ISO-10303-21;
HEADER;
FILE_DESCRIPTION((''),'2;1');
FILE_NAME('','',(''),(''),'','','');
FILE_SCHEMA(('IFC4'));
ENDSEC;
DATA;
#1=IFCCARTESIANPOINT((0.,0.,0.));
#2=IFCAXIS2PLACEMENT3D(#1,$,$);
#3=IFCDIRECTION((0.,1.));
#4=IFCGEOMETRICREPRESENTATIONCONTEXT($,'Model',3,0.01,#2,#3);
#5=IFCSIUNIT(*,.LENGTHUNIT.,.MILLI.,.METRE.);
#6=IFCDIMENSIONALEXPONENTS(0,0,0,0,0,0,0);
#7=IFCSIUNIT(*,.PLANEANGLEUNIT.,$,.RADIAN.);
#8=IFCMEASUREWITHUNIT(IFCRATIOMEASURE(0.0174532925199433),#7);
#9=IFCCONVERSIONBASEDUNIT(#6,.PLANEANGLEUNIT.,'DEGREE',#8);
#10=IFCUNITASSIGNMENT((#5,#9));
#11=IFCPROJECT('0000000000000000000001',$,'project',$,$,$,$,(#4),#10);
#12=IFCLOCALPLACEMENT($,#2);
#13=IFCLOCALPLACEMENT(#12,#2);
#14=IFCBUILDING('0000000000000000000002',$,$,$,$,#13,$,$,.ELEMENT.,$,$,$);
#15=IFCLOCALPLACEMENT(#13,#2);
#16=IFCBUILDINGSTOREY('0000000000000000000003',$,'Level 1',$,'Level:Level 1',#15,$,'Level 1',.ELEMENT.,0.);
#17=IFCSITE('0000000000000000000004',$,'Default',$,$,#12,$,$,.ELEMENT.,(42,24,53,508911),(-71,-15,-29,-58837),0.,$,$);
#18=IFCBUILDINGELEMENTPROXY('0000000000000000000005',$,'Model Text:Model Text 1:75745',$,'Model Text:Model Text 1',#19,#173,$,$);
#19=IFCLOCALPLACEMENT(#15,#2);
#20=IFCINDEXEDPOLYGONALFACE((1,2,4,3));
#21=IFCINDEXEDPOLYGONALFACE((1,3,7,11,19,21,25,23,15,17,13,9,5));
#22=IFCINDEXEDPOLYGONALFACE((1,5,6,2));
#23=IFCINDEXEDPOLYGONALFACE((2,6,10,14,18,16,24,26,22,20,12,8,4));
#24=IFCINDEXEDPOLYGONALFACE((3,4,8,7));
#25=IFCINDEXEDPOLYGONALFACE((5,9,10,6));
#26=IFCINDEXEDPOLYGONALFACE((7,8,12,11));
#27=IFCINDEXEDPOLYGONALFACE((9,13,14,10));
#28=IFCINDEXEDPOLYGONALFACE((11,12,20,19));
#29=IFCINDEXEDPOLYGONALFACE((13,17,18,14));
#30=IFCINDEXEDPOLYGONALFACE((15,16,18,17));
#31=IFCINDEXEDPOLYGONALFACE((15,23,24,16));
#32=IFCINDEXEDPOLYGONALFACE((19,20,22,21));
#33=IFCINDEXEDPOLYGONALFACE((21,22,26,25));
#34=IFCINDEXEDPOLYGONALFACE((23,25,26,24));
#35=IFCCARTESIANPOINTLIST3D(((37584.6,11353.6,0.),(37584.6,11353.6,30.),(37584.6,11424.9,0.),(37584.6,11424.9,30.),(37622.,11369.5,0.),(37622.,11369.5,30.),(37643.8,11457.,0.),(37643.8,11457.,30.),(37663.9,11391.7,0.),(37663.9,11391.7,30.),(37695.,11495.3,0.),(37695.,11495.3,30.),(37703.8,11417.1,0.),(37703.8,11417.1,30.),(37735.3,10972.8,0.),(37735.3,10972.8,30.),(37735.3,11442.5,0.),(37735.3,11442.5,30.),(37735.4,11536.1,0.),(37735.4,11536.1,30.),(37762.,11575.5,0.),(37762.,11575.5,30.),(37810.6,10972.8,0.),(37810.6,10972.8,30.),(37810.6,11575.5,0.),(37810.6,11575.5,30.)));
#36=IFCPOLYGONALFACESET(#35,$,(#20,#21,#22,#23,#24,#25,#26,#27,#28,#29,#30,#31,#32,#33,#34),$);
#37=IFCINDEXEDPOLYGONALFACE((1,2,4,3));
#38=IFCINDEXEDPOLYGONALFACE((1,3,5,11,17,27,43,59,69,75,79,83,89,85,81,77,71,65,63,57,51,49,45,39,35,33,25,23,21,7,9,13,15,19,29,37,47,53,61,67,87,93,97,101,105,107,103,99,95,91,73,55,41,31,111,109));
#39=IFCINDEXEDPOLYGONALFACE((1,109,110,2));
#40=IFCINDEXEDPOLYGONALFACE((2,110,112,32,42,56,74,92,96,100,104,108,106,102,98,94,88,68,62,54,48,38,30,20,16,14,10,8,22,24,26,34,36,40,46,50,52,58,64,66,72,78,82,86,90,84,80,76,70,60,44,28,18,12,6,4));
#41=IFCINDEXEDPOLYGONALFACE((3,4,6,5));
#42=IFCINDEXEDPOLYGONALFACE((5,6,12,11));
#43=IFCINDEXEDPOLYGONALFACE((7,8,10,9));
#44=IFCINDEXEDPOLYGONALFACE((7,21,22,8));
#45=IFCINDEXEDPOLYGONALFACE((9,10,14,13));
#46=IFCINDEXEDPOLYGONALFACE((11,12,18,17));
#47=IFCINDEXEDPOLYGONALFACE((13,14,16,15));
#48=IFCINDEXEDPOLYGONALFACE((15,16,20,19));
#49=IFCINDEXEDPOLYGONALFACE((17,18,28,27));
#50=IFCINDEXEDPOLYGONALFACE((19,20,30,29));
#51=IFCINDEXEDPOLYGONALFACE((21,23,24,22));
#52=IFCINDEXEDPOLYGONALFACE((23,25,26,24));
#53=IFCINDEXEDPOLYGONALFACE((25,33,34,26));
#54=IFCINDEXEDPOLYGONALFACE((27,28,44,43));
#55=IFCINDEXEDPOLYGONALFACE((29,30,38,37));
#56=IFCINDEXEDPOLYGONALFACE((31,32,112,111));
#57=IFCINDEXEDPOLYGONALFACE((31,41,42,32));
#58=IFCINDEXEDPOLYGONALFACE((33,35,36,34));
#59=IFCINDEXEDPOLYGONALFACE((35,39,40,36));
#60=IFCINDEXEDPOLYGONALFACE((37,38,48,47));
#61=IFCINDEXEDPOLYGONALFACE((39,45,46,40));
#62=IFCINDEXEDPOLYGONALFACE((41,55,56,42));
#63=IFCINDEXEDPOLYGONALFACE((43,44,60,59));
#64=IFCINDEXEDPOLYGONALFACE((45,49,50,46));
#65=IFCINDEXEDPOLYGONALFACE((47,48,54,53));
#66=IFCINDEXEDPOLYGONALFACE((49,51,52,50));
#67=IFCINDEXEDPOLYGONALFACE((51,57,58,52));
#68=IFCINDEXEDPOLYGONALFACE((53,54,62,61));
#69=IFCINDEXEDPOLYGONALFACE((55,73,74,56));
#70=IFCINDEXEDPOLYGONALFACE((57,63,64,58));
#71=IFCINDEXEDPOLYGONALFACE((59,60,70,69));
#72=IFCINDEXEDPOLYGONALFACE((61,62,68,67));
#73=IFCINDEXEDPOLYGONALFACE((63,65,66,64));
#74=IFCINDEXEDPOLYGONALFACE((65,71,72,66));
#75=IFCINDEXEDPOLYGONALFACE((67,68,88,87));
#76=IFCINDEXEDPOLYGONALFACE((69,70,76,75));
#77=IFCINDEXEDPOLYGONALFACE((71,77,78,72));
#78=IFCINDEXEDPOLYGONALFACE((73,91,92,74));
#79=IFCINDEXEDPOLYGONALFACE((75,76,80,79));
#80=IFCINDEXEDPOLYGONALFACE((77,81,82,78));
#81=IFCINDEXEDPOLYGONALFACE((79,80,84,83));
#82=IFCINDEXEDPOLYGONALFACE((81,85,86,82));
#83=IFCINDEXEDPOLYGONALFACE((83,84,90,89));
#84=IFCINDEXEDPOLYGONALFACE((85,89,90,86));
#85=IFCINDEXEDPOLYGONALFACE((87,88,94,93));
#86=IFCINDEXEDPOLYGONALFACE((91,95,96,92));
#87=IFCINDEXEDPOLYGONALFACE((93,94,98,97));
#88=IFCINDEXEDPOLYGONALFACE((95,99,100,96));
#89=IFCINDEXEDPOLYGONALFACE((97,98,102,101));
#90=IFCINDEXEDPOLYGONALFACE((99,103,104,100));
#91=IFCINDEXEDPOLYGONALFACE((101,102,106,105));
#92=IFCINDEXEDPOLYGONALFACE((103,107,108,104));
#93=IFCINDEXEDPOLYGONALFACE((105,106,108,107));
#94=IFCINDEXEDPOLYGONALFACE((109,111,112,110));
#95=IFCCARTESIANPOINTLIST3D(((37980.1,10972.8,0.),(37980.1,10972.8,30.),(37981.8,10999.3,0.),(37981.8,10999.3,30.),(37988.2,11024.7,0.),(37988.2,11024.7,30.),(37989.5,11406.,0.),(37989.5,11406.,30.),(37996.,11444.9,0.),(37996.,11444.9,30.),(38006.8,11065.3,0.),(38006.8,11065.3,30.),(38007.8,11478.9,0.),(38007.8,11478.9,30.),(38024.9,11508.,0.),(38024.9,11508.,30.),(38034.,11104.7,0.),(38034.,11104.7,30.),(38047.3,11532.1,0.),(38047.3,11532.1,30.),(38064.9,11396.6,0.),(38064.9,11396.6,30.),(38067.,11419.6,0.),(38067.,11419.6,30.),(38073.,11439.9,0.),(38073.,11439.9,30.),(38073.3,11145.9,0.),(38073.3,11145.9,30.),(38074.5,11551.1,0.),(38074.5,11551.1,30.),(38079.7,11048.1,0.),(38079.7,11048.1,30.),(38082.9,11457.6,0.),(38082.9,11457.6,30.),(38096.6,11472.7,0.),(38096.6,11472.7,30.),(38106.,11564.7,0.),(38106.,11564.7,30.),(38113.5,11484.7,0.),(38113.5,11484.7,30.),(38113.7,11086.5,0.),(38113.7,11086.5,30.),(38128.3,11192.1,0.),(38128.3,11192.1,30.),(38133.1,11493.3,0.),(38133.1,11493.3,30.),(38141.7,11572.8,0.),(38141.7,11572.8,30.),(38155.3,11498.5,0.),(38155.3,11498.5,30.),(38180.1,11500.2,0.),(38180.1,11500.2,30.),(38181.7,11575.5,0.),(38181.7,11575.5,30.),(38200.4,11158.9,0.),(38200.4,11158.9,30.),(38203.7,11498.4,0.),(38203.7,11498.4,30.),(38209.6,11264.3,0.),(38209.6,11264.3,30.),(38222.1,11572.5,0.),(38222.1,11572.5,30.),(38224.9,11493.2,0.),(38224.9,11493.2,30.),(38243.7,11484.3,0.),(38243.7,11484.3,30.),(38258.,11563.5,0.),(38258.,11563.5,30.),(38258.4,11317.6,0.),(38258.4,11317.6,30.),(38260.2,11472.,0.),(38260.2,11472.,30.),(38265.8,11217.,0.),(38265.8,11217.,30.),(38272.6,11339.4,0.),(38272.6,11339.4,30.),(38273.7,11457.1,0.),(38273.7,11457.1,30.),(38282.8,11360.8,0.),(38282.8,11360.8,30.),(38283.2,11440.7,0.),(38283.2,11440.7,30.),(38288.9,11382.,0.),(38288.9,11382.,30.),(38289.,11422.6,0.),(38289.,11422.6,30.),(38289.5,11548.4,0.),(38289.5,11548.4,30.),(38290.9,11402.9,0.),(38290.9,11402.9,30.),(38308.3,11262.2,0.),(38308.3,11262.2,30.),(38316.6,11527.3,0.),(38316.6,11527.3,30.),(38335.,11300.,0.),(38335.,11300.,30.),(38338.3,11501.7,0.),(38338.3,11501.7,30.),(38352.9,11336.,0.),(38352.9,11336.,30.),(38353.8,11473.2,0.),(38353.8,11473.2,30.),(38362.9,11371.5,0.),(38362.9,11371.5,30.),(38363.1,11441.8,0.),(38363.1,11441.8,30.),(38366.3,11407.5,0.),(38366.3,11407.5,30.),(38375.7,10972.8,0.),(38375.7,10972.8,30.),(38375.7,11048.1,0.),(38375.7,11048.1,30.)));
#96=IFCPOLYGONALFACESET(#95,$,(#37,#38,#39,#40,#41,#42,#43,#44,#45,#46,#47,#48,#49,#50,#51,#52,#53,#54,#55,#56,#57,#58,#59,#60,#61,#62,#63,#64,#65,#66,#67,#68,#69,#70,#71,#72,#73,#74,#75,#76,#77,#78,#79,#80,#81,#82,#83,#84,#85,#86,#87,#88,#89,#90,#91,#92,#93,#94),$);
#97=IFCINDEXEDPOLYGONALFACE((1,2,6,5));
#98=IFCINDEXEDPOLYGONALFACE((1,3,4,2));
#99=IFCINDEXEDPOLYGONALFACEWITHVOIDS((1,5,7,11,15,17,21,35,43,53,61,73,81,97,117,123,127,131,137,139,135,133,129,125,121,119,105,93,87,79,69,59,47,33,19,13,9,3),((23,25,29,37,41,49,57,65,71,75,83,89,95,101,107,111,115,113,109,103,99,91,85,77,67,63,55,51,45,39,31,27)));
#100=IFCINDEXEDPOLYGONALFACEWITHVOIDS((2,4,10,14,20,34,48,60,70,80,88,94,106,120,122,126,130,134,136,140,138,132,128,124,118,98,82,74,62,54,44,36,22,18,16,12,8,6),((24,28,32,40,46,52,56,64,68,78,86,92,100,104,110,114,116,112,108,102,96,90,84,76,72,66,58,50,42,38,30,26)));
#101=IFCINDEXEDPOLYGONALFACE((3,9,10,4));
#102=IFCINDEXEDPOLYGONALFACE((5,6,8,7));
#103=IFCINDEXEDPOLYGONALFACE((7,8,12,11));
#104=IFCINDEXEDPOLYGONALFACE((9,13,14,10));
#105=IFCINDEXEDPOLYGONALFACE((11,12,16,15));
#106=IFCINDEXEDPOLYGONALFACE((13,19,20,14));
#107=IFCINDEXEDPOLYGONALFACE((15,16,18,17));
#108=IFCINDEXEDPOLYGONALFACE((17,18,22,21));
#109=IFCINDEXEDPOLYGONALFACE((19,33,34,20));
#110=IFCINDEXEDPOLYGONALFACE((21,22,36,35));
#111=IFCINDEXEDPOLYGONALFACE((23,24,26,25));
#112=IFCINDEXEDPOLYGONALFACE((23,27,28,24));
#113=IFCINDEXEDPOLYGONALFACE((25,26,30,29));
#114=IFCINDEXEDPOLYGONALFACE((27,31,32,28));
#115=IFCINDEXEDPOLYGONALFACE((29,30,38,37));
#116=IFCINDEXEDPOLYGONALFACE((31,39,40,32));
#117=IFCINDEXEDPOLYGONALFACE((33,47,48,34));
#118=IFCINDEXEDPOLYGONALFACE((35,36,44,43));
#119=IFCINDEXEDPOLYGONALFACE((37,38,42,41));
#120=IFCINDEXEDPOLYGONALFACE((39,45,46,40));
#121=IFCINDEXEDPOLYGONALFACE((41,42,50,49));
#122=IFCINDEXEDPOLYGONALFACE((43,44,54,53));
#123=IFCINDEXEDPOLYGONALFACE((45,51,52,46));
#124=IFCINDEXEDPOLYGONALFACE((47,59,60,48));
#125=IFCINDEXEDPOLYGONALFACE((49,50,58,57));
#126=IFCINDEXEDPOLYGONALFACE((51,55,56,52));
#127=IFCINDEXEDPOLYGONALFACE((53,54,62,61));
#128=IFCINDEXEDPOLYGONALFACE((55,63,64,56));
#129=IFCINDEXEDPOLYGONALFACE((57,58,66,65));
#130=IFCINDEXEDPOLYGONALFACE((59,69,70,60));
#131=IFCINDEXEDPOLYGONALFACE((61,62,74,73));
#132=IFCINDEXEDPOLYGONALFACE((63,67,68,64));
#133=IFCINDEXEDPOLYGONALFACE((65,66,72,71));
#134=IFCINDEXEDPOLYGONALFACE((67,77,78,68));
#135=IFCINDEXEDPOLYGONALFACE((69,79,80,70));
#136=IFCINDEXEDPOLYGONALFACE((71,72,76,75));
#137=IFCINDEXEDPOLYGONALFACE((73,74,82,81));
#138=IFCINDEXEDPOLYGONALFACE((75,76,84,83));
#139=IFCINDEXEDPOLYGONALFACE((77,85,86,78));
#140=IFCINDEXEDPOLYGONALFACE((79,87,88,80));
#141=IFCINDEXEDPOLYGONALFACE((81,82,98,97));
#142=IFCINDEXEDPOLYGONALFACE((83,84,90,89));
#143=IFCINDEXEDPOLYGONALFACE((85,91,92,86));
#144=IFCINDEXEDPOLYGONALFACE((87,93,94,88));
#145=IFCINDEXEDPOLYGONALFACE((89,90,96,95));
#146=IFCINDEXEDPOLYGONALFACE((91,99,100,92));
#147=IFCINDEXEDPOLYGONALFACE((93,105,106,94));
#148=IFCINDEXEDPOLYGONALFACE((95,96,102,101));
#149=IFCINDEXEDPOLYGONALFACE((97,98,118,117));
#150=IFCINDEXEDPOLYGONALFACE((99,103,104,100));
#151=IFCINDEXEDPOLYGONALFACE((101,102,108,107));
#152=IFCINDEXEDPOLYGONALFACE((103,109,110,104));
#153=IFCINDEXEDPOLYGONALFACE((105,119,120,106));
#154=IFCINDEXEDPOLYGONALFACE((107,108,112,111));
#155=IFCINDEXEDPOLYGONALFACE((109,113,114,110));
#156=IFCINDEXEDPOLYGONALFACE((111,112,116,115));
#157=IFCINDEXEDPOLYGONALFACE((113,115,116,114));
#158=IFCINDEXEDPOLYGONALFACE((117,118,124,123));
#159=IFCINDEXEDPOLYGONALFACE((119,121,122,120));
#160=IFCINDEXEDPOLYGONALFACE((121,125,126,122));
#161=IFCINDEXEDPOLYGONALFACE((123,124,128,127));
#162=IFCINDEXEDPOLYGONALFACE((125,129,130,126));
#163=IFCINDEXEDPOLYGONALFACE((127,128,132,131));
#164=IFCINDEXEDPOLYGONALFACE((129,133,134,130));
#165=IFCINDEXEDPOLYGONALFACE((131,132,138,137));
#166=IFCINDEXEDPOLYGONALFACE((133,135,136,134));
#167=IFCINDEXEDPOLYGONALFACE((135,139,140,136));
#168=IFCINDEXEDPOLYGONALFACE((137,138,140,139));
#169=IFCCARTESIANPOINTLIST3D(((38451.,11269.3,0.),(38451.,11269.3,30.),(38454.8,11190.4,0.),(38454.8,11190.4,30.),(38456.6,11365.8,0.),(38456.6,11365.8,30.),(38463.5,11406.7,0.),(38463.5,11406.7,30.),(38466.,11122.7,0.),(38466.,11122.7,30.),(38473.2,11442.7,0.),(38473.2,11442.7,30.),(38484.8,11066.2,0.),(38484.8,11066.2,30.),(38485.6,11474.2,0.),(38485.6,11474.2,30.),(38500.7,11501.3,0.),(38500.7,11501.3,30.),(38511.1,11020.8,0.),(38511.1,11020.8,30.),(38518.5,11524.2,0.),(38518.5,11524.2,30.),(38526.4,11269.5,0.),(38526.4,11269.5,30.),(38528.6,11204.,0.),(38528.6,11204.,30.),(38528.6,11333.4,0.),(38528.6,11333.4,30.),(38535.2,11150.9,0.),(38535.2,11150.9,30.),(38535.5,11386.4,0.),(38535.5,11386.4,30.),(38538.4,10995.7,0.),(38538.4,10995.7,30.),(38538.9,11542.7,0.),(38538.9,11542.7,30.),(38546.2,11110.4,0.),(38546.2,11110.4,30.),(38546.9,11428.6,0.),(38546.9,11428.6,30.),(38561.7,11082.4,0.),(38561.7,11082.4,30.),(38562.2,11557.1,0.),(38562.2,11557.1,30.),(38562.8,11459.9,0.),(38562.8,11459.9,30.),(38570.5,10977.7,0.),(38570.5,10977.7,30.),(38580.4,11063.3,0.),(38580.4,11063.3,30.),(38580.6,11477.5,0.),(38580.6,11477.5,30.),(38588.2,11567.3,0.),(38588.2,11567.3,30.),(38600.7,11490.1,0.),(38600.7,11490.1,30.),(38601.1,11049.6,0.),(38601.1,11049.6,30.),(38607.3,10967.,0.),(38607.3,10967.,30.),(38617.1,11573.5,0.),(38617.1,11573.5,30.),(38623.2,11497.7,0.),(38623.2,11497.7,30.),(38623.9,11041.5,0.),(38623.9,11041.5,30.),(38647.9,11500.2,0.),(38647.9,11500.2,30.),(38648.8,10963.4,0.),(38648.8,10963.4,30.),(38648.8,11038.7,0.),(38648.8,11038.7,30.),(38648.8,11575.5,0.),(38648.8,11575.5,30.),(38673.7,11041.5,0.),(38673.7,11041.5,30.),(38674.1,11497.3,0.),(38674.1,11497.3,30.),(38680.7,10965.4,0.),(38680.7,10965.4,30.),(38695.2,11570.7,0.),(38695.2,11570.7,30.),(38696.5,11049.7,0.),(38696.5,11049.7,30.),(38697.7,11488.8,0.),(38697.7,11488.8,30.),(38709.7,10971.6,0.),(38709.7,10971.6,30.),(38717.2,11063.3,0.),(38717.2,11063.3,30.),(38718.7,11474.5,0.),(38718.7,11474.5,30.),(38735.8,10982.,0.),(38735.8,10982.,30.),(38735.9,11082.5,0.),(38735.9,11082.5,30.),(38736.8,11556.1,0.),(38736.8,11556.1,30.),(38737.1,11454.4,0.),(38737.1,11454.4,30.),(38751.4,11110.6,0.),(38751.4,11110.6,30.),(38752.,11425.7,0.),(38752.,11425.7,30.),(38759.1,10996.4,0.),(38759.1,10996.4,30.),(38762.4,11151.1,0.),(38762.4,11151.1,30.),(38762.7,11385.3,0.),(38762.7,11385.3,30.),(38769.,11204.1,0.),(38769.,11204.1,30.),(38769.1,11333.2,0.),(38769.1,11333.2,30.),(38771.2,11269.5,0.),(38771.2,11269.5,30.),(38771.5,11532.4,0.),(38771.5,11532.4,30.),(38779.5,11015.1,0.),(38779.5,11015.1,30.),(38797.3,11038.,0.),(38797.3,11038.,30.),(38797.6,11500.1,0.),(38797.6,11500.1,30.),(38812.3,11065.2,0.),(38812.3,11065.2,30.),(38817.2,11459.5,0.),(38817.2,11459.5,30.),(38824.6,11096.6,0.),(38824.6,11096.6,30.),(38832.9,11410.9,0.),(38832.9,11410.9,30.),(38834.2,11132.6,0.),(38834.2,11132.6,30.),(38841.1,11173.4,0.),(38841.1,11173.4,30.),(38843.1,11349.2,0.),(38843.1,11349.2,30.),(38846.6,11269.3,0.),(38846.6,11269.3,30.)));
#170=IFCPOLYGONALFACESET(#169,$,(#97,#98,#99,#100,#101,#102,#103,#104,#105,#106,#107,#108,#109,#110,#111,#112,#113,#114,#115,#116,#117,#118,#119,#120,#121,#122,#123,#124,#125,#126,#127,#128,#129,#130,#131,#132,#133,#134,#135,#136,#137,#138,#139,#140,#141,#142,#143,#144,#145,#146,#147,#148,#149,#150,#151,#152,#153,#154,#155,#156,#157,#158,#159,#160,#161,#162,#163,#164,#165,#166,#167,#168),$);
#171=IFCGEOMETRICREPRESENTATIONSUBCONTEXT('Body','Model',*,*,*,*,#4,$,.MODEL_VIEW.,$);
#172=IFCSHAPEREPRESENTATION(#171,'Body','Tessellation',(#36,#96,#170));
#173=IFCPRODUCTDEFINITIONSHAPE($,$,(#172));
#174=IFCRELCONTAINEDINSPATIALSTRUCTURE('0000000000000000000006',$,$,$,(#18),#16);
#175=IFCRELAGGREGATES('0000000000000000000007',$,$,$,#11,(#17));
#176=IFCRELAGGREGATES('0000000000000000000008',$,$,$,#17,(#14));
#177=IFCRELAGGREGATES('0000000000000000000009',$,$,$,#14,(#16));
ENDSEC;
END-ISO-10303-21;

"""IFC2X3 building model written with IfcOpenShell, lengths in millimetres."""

from ifc_helpers import new_model, entity, si_unit, converted_unit, direction, frame, origin, place, context, subcontext, project, spatial, polyline, outline, extrude, element, save


model = new_model("IFC2X3")

# Units and contexts
model_context = context("Model", 3, precision=0.01, world=origin(), true_north=direction((0.0, 1.0)))
body_context = subcontext(model_context, "Body", "Model", "MODEL_VIEW")
ifc_project = project(units=[si_unit("LENGTHUNIT", "METRE", prefix="MILLI"), converted_unit("PLANEANGLEUNIT", "DEGREE", entity("IfcRatioMeasure", 0.0174532925199433), si_unit("PLANEANGLEUNIT", "RADIAN"), dimensions=[0, 0, 0, 0, 0, 0, 0])], contexts=[model_context])

# Site, building, storey
site_placement = place(None, origin())
site = spatial("IfcSite", under=ifc_project, at=site_placement, Name="Default", CompositionType="ELEMENT", RefLatitude=(42, 24, 53, 508911), RefLongitude=(-71, -15, -29, -58837), RefElevation=0.0)
building_placement = place(site_placement, origin())
building = spatial("IfcBuilding", under=site, at=building_placement, CompositionType="ELEMENT")
storey_placement = place(building_placement, origin())
storey = spatial("IfcBuildingStorey", under=building, at=storey_placement, Name="Level 1", ObjectType="Level:Level 1", LongName="Level 1", CompositionType="ELEMENT", Elevation=0.0)

# Building element proxy
proxy_1_placement = place(storey_placement, origin())
element("IfcBuildingElementProxy", 1, at=proxy_1_placement, inside=storey, Name="Model Text:Model Text 1:75745", ObjectType="Model Text:Model Text 1", context=body_context, shape_type="SweptSolid", body=[
    extrude(outline(polyline([(-410.6, -111.6), (192.1, -111.6), (192.1, -63.1), (152.7, -36.4), (111.9, 4.0), (73.6, 55.2), (41.4, 114.4), (-29.8, 114.4), (-13.9, 77.0), (8.3, 35.1), (33.7, -4.8), (59.1, -36.3), (-410.6, -36.3), (-410.6, -111.6)])), frame((37699.0, 11383.4, 0.0), z_axis=(0.0, 0.0, 1.0), x_axis=(0.0, 1.0, 0.0)), (0.0, 0.0, 1.0), 30.0),
    extrude(outline(polyline([(-190.2, -317.5), (-190.2, -392.8), (205.4, -392.8), (203.7, -366.3), (197.3, -340.9), (178.7, -300.3), (151.5, -260.9), (112.2, -219.7), (57.2, -173.6), (-24.1, -101.3), (-72.9, -48.0), (-87.1, -26.3), (-97.3, -4.8), (-103.4, 16.4), (-105.4, 37.3), (-103.5, 57.0), (-97.7, 75.0), (-88.2, 91.5), (-74.7, 106.4), (-58.2, 118.7), (-39.4, 127.5), (-18.2, 132.8), (5.4, 134.6), (30.2, 132.9), (52.4, 127.7), (72.0, 119.1), (88.9, 107.1), (102.6, 92.0), (112.5, 74.3), (118.5, 54.0), (120.6, 31.0), (196.0, 40.4), (189.5, 79.3), (177.7, 113.3), (160.6, 142.4), (138.2, 166.5), (111.0, 185.5), (79.5, 199.1), (43.8, 207.2), (3.8, 209.9), (-36.6, 206.9), (-72.5, 197.9), (-104.0, 182.8), (-131.1, 161.7), (-152.8, 136.1), (-168.3, 107.6), (-177.6, 76.2), (-180.8, 41.9), (-177.4, 5.8), (-167.4, -29.6), (-149.5, -65.6), (-122.8, -103.4), (-80.3, -148.6), (-14.9, -206.7), (71.8, -279.1), (105.8, -317.5), (-190.2, -317.5)])), frame((38185.5, 11365.6, 0.0), z_axis=(0.0, 0.0, -1.0), x_axis=(-1.0, 0.0, 0.0)), (0.0, 0.0, -1.0), 30.0),
    extrude(outline(polyline([(-10.6, -198.7), (68.3, -198.7), (136.5, -190.7), (193.9, -174.7), (240.5, -150.6), (266.9, -124.4), (286.3, -93.2), (298.8, -57.0), (304.3, -15.7), (303.8, 16.2), (299.0, 45.5), (289.9, 72.1), (276.6, 96.0), (258.9, 117.3), (236.9, 136.2), (210.4, 152.5), (179.6, 166.3), (144.1, 177.6), (103.7, 186.3), (8.2, 196.4), (-71.8, 196.7), (-134.0, 189.4), (-183.3, 176.1), (-224.7, 158.4), (-258.2, 133.9), (-283.5, 100.3), (-300.1, 59.5), (-307.1, 13.4), (-306.6, -18.4), (-301.8, -47.5), (-292.8, -74.0), (-279.6, -97.9), (-262.0, -119.2), (-240.0, -138.1), (-213.6, -154.5), (-182.8, -168.4), (-147.3, -179.8), (-106.7, -188.6), (-10.6, -198.7)]), holes=[polyline([(-7.2, -123.5), (-71.0, -118.2), (-123.6, -108.8), (-165.2, -95.4), (-195.7, -78.0), (-212.4, -59.4), (-224.1, -38.7), (-230.6, -15.9), (-231.9, 8.9), (-227.8, 35.0), (-218.1, 58.1), (-202.8, 78.4), (-182.0, 95.8), (-152.6, 109.4), (-111.7, 118.1), (-59.4, 122.0), (4.4, 121.1), (69.6, 115.8), (122.2, 106.7), (162.2, 93.7), (189.5, 77.0), (207.7, 57.4), (220.4, 36.0), (227.5, 12.8), (229.1, -12.1), (225.2, -36.8), (215.9, -59.2), (201.3, -79.3), (181.4, -97.1), (152.6, -111.2), (111.6, -120.3), (58.3, -124.4), (-7.2, -123.5)])]), frame((38650.0, 11268.1, 0.0), z_axis=(0.0, 0.0, 1.0), x_axis=(0.047515, -0.998871, 0.0)), (0.0, 0.0, 1.0), 30.0),
])

save(model, "model.ifc")
